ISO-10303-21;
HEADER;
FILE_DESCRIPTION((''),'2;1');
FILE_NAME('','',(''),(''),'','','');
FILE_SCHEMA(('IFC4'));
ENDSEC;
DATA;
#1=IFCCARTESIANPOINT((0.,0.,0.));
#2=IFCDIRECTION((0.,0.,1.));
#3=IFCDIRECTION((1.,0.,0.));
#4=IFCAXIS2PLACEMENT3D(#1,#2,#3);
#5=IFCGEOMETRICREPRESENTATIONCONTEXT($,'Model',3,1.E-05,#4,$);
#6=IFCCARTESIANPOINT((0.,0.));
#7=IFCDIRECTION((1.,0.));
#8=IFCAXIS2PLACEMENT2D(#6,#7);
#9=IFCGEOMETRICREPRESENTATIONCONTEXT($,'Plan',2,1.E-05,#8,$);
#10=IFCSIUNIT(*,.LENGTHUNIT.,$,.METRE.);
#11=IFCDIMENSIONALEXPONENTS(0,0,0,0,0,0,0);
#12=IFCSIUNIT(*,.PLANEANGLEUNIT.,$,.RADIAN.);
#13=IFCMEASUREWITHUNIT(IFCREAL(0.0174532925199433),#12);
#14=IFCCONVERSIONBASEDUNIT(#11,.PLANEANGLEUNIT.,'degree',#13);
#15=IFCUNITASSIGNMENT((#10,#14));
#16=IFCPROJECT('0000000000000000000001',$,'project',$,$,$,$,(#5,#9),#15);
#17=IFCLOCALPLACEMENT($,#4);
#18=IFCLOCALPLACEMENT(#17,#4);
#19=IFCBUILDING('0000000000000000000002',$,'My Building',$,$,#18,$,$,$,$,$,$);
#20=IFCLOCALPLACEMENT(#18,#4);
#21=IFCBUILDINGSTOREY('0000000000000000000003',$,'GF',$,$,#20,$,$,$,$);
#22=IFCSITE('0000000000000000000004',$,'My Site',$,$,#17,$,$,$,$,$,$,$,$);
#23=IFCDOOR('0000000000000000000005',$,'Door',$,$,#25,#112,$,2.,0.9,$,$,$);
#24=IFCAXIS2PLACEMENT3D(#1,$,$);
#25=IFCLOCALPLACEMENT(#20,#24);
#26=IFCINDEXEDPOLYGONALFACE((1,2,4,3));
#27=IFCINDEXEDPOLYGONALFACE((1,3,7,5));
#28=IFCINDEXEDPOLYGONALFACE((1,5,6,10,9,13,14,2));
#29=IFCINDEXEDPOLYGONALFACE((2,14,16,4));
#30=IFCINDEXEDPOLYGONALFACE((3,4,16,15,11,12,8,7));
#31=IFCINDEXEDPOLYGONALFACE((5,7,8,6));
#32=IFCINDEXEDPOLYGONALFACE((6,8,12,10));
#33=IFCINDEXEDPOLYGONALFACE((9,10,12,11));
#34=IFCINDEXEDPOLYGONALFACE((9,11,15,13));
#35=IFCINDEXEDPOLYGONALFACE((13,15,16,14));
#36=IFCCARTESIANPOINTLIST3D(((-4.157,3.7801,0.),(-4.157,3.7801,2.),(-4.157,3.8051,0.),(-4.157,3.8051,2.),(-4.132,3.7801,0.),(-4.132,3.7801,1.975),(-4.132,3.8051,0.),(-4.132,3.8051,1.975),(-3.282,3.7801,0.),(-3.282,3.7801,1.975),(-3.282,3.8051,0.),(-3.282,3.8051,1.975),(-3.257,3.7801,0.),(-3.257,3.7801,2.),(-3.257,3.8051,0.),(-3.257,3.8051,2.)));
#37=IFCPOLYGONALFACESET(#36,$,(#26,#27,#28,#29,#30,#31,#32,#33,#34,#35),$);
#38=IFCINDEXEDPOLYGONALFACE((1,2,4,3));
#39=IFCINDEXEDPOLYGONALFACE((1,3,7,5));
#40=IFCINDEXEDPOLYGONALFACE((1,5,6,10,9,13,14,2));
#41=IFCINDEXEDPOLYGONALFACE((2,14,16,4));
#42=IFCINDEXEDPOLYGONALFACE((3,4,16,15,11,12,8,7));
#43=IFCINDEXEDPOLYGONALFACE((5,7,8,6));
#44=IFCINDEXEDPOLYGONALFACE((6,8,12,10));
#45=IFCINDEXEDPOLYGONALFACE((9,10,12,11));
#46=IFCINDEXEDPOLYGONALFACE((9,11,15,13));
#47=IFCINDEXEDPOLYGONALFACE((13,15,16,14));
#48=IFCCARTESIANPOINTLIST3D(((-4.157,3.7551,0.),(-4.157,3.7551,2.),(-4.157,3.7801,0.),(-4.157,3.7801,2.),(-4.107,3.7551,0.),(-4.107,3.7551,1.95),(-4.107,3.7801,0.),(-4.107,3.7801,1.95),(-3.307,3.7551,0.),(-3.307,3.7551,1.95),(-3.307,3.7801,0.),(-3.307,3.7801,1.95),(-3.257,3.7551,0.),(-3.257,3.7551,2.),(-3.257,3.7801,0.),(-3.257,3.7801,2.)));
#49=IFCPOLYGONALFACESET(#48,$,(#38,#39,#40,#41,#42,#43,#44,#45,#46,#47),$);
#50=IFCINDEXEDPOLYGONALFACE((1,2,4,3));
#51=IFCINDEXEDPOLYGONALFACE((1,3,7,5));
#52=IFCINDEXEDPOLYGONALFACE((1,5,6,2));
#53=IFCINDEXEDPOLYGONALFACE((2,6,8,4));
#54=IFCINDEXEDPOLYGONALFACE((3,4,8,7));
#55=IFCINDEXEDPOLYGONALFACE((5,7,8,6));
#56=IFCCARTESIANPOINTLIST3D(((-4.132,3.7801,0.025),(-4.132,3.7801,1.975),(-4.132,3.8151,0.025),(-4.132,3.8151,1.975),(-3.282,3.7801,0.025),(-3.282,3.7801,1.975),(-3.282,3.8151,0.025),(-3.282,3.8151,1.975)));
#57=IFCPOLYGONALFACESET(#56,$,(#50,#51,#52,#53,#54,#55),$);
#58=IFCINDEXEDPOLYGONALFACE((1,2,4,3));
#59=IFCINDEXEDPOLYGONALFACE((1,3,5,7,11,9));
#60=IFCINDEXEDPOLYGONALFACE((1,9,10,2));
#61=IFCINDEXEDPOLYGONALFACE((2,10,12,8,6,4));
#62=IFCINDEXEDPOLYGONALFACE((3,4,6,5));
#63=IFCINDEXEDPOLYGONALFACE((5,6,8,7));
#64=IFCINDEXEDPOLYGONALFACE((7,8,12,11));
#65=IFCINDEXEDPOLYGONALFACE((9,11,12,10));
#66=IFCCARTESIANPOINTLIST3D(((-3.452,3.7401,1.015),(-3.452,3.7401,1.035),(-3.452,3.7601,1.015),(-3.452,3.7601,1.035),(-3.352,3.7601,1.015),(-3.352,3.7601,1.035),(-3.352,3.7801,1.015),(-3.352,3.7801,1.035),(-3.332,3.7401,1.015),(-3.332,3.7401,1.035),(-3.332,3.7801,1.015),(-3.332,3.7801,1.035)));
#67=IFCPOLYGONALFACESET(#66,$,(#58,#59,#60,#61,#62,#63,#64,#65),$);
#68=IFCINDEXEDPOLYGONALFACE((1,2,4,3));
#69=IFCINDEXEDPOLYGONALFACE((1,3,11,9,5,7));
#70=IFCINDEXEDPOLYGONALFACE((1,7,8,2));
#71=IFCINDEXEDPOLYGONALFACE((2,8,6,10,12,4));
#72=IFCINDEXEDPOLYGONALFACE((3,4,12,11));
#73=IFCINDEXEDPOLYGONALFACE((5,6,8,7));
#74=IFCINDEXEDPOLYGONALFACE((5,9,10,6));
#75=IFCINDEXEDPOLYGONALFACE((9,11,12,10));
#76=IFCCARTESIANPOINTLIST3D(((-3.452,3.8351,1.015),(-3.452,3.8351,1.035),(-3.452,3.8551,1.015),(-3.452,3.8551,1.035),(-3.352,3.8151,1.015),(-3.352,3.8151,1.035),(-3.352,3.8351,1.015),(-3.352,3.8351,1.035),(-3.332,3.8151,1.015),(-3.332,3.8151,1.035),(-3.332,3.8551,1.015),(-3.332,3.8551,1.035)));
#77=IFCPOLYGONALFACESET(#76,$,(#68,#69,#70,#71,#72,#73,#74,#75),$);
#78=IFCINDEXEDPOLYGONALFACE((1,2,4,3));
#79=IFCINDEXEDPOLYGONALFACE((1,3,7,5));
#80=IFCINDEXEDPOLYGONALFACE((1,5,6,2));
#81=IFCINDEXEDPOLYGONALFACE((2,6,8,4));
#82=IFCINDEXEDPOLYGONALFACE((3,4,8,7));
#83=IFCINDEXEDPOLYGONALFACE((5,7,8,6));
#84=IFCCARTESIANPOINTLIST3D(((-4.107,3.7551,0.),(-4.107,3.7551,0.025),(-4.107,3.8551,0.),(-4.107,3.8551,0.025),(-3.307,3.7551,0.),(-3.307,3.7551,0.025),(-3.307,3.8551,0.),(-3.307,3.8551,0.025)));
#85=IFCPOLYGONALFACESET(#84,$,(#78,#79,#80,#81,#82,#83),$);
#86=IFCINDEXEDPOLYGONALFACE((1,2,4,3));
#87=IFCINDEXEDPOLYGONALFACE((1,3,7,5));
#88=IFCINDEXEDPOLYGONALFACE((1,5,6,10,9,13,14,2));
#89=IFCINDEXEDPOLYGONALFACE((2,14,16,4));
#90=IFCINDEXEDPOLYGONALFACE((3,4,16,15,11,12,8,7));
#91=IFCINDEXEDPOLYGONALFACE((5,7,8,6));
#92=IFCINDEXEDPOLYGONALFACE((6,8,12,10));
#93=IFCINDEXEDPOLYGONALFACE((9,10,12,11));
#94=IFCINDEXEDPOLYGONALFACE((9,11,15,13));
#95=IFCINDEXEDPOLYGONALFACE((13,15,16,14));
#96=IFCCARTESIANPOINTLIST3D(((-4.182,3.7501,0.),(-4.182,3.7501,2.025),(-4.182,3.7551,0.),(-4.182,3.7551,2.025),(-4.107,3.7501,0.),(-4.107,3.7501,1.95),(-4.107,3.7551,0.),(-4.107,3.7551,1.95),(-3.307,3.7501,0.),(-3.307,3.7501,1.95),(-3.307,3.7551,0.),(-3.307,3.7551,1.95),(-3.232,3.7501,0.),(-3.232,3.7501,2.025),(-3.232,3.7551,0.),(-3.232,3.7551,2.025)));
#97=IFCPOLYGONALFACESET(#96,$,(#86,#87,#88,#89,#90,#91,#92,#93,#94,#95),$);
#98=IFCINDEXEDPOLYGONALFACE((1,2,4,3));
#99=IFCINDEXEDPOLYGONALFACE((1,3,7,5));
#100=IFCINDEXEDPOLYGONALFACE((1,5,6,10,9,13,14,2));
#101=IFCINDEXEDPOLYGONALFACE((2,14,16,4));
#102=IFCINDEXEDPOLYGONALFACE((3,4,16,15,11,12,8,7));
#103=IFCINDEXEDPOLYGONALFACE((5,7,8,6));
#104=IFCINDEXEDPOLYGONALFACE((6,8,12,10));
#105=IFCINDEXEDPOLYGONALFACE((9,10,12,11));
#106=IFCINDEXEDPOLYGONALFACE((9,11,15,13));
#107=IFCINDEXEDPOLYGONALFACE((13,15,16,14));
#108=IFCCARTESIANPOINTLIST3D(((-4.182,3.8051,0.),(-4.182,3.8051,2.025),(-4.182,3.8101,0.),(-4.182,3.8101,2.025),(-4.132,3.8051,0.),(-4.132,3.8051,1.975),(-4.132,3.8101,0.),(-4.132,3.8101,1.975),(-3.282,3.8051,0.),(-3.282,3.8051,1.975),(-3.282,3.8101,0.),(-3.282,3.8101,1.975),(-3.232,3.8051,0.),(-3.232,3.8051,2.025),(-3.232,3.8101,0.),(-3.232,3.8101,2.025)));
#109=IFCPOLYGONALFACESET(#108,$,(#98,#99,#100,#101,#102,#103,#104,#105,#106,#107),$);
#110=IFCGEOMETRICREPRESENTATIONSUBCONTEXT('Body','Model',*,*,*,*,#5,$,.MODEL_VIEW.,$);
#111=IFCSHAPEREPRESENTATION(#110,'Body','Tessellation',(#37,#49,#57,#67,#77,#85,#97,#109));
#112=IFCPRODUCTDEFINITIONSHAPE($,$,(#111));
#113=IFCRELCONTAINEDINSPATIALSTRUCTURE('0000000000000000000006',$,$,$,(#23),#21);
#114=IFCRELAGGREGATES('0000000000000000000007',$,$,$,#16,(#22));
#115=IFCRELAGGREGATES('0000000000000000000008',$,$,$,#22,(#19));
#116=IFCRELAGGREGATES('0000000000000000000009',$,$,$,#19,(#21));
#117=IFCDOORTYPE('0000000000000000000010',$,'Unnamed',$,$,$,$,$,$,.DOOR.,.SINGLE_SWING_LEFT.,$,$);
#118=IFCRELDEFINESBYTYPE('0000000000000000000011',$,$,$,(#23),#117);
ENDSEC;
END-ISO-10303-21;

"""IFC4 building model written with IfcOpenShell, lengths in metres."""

from ifc_helpers import new_model, entity, si_unit, converted_unit, frame, origin_with_axes, origin_2d_with_axis, place, context, subcontext, project, spatial, line, indexed_curve, outline, extrude, shape, source, transform, mapped, type_object, type_shapes, element, save


model = new_model("IFC4")

# Units and contexts
model_context = context("Model", 3, precision=1e-05, world=origin_with_axes())
plan_context = context("Plan", 2, precision=1e-05, world=origin_2d_with_axis())
body_context_1 = subcontext(model_context, "Body", "Model", "MODEL_VIEW")
body_context_2 = subcontext(plan_context, "Body", "Plan", "PLAN_VIEW")
ifc_project = project(units=[si_unit("LENGTHUNIT", "METRE"), converted_unit("PLANEANGLEUNIT", "degree", entity("IfcReal", 0.0174532925199433), si_unit("PLANEANGLEUNIT", "RADIAN"), dimensions=[0, 0, 0, 0, 0, 0, 0])], contexts=[model_context, plan_context])

# Site, building, storey
site_placement = place(None, origin_with_axes())
site = spatial("IfcSite", under=ifc_project, at=site_placement, Name="My Site")
building_placement = place(site_placement, origin_with_axes())
building = spatial("IfcBuilding", under=site, at=building_placement, Name="My Building")
storey_placement = place(building_placement, origin_with_axes())
storey = spatial("IfcBuildingStorey", under=building, at=storey_placement, Name="GF")

# Door
door_type = type_object("IfcDoorType", Name="Unnamed", OperationType="SINGLE_SWING_LEFT", PredefinedType="DOOR")
shared_shape_1 = source(origin_with_axes(), body_context_1, "Body", "SweptSolid", [
    extrude(outline(indexed_curve([(0.0, 0.0), (0.0, 2.0), (0.9, 2.0), (0.9, 0.0), (0.875, 0.0), (0.875, 1.975), (0.025, 1.975), (0.025, 0.0)], segments=[line(1, 2, 3, 4, 5, 6, 7, 8, 1)])), frame((0.0, 0.025, 0.0), z_axis=(0.0, -1.0, 0.0), x_axis=(1.0, 0.0, 0.0)), (0.0, 0.0, -1.0), 0.025),
    extrude(outline(indexed_curve([(0.0, 0.0), (0.0, 2.0), (0.9, 2.0), (0.9, 0.0), (0.85, 0.0), (0.85, 1.95), (0.05, 1.95), (0.05, 0.0)], segments=[line(1, 2, 3, 4, 5, 6, 7, 8, 1)])), frame((0.0, 0.0, 0.0), z_axis=(0.0, -1.0, 0.0), x_axis=(1.0, 0.0, 0.0)), (0.0, 0.0, -1.0), 0.025),
    extrude(outline(indexed_curve([(0.0, 0.0), (0.85, 0.0), (0.85, 0.035), (0.0, 0.035)], segments=[line(1, 2, 3, 4, 1)])), frame((0.025, 0.025, 0.025), z_axis=(0.0, 0.0, 1.0), x_axis=(1.0, 0.0, 0.0)), (0.0, 0.0, 1.0), 1.95),
    extrude(outline(indexed_curve([(0.0, 0.0), (0.0, -0.04), (-0.12, -0.04), (-0.12, -0.02), (-0.02, -0.02), (-0.02, 0.0)], segments=[line(1, 2, 3, 4, 5, 6, 1)])), frame((0.825, 0.025, 1.015), z_axis=(0.0, 0.0, 1.0), x_axis=(1.0, 0.0, 0.0)), (0.0, 0.0, 1.0), 0.02),
    extrude(outline(indexed_curve([(0.0, 0.0), (0.0, 0.04), (-0.12, 0.04), (-0.12, 0.02), (-0.02, 0.02), (-0.02, 0.0)], segments=[line(1, 2, 3, 4, 5, 6, 1)])), frame((0.825, 0.06, 1.015), z_axis=(0.0, 0.0, 1.0), x_axis=(1.0, 0.0, 0.0)), (0.0, 0.0, 1.0), 0.02),
    extrude(outline(indexed_curve([(0.0, 0.0), (0.8, 0.0), (0.8, 0.1), (0.0, 0.1)], segments=[line(1, 2, 3, 4, 1)])), frame((0.05, 0.0, 0.0), z_axis=(0.0, 0.0, 1.0), x_axis=(1.0, 0.0, 0.0)), (0.0, 0.0, 1.0), 0.025),
    extrude(outline(indexed_curve([(0.0, 0.0), (0.0, 2.025), (0.95, 2.025), (0.95, 0.0), (0.875, 0.0), (0.875, 1.95), (0.075, 1.95), (0.075, 0.0)], segments=[line(1, 2, 3, 4, 5, 6, 7, 8, 1)])), frame((-0.025, -0.005, 0.0), z_axis=(0.0, -1.0, 0.0), x_axis=(1.0, 0.0, 0.0)), (0.0, 0.0, -1.0), 0.005),
    extrude(outline(indexed_curve([(0.0, 0.0), (0.0, 2.025), (0.95, 2.025), (0.95, 0.0), (0.9, 0.0), (0.9, 1.975), (0.05, 1.975), (0.05, 0.0)], segments=[line(1, 2, 3, 4, 5, 6, 7, 8, 1)])), frame((-0.025, 0.05, 0.0), z_axis=(0.0, -1.0, 0.0), x_axis=(1.0, 0.0, 0.0)), (0.0, 0.0, -1.0), 0.005),
])
shared_shape_2 = source(origin_with_axes(), body_context_2, "Body", "Curve2D", [
    entity("IfcIndexedPolyCurve", entity("IfcCartesianPointList2D", [[0.0, 0.0], [0.0, 0.05], [0.025, 0.05], [0.025, 0.025], [0.05, 0.025], [0.05, 0.0]]), [entity("IfcLineIndex", [1, 2, 3, 4, 5, 6, 1])]),
    entity("IfcIndexedPolyCurve", entity("IfcCartesianPointList2D", [[0.9, 0.0], [0.9, 0.05], [0.875, 0.05], [0.875, 0.025], [0.85, 0.025], [0.85, 0.0]]), [entity("IfcLineIndex", [1, 2, 3, 4, 5, 6, 1])]),
    entity("IfcTrimmedCurve", entity("IfcEllipse", entity("IfcAxis2Placement2D", entity("IfcCartesianPoint", [0.06, 0.05]), entity("IfcDirection", [1.0, 0.0])), 0.815, 0.85), [entity("IfcCartesianPoint", [0.875, 0.05])], [entity("IfcCartesianPoint", [0.06, 0.9])], True, "CARTESIAN"),
    entity("IfcIndexedPolyCurve", entity("IfcCartesianPointList2D", [[0.025, 0.05], [0.06, 0.05], [0.06, 0.9], [0.025, 0.9]]), [entity("IfcLineIndex", [1, 2, 3, 4, 1])]),
])
type_shapes(door_type, [shared_shape_1, shared_shape_2])
door_placement = place(storey_placement, frame((-4.157, 3.7551, 0.0), z_axis=(0.0, 0.0, 1.0), x_axis=(1.0, 0.0, 0.0)))
element("IfcDoor", 1, at=door_placement, inside=storey, type_object=door_type, Name="Door", OverallHeight=2.0, OverallWidth=0.9, shapes=[
    shape(body_context_1, "Body", "MappedRepresentation", [mapped(shared_shape_1, transform((0.0, 0.0, 0.0), x_axis=(1.0, 0.0, 0.0), y_axis=(0.0, 1.0, 0.0), z_axis=(0.0, 0.0, 1.0), scale=1.0))]),
    shape(body_context_2, "Body", "MappedRepresentation", [mapped(shared_shape_2, transform((0.0, 0.0, 0.0), x_axis=(1.0, 0.0, 0.0), y_axis=(0.0, 1.0, 0.0), z_axis=(0.0, 0.0, 1.0), scale=1.0))]),
])

save(model, "model.ifc")
